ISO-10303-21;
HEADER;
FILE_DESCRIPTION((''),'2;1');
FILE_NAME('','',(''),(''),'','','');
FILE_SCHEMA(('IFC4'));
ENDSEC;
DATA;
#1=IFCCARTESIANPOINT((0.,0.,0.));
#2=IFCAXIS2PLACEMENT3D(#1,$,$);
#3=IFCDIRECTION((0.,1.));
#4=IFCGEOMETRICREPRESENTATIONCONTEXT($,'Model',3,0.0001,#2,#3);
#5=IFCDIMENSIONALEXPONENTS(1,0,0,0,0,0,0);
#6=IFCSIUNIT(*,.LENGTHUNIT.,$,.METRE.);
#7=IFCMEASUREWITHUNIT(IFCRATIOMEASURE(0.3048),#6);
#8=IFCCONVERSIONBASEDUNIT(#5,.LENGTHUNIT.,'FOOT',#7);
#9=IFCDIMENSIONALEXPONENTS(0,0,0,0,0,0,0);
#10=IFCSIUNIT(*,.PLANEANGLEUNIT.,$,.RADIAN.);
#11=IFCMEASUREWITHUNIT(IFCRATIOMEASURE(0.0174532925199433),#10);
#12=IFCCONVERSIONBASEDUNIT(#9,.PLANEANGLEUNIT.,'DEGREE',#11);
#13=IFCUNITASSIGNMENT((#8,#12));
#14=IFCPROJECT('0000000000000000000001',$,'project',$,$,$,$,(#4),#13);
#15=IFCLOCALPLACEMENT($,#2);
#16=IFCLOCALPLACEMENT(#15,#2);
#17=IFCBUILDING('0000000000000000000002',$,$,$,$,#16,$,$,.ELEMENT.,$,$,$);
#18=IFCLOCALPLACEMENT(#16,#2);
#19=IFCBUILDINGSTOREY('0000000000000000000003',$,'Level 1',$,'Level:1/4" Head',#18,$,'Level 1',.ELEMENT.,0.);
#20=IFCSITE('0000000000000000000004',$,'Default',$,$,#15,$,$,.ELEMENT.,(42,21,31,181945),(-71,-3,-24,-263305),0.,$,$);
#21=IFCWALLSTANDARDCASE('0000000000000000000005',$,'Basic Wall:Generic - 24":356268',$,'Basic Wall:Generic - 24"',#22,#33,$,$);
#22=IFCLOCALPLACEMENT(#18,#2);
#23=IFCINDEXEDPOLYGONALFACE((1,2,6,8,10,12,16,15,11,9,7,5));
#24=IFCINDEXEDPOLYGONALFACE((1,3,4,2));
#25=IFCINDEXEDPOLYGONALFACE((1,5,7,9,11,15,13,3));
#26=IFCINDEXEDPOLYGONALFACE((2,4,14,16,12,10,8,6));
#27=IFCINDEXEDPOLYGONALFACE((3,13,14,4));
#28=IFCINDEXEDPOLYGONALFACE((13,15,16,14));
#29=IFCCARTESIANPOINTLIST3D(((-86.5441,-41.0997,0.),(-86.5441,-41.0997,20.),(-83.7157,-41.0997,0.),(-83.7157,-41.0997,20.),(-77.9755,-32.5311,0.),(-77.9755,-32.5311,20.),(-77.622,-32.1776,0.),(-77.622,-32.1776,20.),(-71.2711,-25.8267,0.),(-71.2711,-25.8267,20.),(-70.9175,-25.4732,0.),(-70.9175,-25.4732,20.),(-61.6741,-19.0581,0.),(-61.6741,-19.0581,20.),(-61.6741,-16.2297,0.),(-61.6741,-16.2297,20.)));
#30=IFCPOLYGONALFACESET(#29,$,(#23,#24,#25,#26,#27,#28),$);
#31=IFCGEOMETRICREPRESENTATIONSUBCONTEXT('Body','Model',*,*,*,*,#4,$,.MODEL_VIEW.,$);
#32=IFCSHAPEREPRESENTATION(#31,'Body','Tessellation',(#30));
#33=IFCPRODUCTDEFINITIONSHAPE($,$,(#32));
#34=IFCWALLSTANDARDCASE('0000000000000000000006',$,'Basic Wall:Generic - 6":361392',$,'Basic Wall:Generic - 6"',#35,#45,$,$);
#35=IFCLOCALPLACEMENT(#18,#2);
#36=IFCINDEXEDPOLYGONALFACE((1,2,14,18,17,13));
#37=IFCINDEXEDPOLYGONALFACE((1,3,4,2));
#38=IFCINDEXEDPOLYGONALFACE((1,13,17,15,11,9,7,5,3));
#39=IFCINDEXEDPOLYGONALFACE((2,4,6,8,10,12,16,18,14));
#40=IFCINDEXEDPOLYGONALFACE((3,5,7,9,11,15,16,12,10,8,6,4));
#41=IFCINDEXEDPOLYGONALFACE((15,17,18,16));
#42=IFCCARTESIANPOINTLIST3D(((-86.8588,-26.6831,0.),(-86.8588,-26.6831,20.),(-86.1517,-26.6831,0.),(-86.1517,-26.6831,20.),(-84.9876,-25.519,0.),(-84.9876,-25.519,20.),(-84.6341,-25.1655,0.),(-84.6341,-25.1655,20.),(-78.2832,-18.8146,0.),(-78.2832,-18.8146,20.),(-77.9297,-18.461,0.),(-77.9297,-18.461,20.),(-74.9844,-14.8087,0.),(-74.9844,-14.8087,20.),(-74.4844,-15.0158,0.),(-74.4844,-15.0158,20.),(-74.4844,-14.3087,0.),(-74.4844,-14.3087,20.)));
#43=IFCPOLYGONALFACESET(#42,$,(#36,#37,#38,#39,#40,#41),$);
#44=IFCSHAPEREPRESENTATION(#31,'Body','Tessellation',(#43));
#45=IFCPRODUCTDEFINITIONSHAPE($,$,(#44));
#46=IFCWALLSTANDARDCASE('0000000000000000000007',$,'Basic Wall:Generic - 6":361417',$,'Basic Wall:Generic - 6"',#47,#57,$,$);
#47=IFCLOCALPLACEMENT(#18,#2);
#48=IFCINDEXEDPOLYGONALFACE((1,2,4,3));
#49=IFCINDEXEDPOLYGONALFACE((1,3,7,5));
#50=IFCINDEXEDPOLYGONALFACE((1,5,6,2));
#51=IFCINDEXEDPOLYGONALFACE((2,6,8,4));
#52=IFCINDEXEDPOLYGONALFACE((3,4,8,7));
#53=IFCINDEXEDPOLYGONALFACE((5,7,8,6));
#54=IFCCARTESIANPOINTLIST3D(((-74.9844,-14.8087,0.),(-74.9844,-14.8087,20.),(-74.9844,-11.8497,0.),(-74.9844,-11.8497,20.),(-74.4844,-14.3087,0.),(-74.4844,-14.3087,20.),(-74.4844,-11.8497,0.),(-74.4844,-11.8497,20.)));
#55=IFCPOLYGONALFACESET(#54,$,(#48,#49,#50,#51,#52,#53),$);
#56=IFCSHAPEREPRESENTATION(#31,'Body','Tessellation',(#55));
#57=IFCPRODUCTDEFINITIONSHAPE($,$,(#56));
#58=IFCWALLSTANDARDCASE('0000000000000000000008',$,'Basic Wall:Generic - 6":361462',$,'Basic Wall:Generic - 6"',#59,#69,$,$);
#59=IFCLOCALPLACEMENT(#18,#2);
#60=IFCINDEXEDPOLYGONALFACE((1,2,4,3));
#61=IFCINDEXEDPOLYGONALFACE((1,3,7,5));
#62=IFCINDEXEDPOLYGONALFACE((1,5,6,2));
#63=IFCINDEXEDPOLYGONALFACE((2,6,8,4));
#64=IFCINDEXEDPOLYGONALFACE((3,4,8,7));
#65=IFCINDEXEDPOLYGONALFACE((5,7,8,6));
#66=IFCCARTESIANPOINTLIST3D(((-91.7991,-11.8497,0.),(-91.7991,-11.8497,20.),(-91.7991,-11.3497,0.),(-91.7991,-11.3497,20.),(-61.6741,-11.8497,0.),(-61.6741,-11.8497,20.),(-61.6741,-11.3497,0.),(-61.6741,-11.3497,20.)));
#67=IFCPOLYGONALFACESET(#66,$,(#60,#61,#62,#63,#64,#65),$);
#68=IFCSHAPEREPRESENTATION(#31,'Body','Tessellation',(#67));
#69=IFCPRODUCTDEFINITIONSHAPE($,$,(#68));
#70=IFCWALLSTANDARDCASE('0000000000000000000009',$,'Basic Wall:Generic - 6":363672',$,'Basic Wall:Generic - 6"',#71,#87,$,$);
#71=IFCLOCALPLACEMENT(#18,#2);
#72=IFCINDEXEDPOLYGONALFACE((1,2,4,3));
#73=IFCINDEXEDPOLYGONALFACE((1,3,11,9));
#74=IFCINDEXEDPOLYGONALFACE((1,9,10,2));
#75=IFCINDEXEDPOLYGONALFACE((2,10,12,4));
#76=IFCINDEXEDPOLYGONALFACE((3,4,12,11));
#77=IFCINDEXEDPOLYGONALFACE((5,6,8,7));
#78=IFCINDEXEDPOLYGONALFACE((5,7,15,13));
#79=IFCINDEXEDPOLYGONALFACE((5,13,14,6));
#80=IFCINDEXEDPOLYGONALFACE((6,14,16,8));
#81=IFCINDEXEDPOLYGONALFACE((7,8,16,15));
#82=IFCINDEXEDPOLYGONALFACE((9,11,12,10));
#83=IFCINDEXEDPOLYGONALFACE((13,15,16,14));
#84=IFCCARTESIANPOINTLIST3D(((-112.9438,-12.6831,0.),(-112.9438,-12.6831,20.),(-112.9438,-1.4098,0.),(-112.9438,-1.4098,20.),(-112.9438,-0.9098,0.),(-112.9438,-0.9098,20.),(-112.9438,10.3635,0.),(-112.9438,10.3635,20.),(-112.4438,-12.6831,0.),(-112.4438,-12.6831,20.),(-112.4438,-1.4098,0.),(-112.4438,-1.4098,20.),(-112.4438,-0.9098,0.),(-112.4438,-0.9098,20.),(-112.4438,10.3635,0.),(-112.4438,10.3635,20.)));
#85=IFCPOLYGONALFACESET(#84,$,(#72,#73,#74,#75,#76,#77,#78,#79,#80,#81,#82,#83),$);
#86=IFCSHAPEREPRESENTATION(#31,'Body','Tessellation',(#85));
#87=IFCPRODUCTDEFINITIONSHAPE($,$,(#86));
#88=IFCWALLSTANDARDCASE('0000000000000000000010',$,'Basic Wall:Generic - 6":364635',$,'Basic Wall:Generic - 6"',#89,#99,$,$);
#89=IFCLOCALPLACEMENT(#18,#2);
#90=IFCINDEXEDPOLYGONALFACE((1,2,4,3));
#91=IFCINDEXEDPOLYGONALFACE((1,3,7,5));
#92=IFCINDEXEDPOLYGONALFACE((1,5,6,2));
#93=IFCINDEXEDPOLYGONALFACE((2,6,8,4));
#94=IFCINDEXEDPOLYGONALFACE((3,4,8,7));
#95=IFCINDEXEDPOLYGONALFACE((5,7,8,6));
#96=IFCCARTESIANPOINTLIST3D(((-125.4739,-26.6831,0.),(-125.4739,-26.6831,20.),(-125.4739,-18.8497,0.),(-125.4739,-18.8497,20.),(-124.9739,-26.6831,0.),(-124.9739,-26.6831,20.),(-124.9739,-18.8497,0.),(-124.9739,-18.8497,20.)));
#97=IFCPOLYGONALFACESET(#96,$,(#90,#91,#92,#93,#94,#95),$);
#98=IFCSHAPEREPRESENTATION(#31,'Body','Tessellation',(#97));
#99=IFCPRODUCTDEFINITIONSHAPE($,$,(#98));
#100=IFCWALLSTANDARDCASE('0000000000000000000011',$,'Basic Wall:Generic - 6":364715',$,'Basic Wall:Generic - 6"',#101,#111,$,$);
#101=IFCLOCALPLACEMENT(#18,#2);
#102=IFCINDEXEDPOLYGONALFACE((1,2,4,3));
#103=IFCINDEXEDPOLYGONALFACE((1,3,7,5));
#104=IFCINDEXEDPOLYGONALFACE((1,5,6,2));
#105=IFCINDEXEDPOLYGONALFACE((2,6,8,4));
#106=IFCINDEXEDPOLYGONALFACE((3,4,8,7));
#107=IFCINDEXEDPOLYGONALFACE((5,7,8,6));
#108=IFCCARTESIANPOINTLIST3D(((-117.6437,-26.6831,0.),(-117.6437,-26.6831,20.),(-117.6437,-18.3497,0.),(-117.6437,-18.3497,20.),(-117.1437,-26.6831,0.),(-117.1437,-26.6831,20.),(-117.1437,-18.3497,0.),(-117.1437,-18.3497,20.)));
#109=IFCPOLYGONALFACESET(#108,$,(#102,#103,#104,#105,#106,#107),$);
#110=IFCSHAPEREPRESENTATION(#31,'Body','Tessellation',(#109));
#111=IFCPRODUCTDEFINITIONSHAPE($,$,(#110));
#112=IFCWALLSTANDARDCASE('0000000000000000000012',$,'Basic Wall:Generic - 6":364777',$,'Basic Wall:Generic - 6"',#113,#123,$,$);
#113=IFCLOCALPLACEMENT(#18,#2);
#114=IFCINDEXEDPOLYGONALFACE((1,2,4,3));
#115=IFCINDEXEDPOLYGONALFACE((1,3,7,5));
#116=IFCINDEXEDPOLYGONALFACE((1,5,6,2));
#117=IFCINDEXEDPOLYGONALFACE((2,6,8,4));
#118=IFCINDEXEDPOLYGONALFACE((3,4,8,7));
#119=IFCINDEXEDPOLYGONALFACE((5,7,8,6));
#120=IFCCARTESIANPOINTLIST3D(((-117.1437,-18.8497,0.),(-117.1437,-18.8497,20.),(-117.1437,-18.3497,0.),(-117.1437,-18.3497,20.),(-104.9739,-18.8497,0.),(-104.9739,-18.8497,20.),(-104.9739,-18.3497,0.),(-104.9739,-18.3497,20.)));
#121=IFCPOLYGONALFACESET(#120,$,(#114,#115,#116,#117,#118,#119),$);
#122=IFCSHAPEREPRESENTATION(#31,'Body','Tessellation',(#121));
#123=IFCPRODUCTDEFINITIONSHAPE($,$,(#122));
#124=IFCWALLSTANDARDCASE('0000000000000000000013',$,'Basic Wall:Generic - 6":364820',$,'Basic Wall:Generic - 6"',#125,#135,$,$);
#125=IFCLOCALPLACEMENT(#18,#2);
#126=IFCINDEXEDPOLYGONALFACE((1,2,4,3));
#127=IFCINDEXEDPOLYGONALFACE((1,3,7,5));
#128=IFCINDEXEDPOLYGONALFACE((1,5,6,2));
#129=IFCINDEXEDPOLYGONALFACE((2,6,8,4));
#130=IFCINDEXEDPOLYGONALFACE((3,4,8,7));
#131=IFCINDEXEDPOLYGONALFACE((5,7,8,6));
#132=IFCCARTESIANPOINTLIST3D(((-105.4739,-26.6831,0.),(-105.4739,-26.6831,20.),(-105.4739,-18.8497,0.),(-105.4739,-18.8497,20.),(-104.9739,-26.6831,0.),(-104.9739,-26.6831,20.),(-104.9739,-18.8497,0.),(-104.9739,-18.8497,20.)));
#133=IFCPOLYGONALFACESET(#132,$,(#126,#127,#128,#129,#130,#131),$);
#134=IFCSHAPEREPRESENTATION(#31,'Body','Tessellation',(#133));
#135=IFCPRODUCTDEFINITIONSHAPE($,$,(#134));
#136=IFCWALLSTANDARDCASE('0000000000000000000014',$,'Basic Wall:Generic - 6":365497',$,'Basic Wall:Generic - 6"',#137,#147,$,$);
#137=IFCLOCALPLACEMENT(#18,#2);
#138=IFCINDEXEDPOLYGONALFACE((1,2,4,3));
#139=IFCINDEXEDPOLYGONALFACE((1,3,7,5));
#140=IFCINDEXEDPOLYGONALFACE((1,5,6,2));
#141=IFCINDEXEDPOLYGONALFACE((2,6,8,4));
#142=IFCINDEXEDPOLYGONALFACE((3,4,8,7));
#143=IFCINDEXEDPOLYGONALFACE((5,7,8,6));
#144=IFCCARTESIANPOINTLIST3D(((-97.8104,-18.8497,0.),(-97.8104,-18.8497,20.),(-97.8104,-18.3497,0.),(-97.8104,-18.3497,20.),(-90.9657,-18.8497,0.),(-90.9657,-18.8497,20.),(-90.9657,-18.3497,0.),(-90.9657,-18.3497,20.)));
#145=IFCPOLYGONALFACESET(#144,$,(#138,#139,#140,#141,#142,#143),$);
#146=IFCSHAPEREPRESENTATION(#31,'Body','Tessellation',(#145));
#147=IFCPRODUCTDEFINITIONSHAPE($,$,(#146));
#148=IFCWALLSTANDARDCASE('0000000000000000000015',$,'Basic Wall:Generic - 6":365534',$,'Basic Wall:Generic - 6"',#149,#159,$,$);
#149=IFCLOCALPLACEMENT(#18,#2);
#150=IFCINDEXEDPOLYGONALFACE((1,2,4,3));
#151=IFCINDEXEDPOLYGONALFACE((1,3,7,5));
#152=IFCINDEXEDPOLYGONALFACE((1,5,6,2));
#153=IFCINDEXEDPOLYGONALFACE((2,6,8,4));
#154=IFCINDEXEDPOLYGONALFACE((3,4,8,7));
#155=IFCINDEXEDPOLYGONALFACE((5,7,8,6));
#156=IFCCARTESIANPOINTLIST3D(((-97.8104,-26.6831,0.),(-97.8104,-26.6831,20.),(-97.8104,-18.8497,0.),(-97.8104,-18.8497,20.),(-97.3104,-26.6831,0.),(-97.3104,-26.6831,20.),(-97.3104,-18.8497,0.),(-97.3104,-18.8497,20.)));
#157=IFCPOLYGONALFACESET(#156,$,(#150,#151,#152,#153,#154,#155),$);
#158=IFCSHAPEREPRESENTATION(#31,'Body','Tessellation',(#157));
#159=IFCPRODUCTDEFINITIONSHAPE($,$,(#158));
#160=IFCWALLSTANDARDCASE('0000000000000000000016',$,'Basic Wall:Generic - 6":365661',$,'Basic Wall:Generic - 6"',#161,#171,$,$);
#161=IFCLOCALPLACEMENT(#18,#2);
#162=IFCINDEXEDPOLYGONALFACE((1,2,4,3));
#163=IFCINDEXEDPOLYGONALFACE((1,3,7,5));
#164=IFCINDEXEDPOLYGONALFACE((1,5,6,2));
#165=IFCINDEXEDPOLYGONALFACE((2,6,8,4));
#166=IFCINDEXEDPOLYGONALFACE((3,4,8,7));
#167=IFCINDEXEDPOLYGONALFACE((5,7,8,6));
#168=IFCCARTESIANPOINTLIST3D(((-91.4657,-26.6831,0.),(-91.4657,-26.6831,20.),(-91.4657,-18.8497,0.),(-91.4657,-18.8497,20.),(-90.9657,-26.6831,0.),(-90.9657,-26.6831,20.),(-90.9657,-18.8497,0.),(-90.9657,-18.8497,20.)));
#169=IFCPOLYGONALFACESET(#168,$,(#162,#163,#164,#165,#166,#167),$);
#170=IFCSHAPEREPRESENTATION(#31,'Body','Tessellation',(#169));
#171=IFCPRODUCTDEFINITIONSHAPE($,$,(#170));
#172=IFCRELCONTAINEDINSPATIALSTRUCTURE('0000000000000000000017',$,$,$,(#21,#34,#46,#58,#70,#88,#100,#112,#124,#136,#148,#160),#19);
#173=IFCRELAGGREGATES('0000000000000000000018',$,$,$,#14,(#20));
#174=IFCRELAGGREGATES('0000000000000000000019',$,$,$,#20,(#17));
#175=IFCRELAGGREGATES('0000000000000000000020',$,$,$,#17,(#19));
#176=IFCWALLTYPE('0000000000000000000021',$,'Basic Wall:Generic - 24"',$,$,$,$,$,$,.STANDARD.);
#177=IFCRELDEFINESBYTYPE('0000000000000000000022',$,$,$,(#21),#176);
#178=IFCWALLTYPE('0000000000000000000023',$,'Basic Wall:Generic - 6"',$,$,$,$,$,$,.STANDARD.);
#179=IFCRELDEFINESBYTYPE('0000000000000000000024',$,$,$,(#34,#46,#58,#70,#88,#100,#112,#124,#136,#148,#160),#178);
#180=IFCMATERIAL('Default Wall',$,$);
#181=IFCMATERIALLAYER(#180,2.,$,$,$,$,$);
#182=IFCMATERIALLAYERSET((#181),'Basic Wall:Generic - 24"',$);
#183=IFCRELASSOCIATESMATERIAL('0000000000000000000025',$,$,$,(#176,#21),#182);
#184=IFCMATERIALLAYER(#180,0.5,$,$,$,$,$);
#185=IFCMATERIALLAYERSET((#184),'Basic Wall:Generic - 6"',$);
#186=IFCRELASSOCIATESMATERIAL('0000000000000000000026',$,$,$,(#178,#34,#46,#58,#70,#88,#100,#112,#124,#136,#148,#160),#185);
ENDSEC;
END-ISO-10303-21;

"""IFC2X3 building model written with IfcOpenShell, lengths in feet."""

from ifc_helpers import new_model, entity, si_unit, converted_unit, direction, frame, frame_2d, origin, origin_2d_with_axis, place, context, subcontext, project, spatial, polyline, rectangle, outline, extrude, material, layer, layer_set, layer_usage, type_object, element, save


model = new_model("IFC2X3")

# Units and contexts
model_context = context("Model", 3, precision=0.0001, world=origin(), true_north=direction((0.0, 1.0)))
body_context = subcontext(model_context, "Body", "Model", "MODEL_VIEW")
ifc_project = project(units=[converted_unit("LENGTHUNIT", "FOOT", entity("IfcRatioMeasure", 0.3048), si_unit("LENGTHUNIT", "METRE"), dimensions=[1, 0, 0, 0, 0, 0, 0]), converted_unit("PLANEANGLEUNIT", "DEGREE", entity("IfcRatioMeasure", 0.0174532925199433), si_unit("PLANEANGLEUNIT", "RADIAN"), dimensions=[0, 0, 0, 0, 0, 0, 0])], contexts=[model_context])

# Site, building, storey
site_placement = place(None, origin())
site = spatial("IfcSite", under=ifc_project, at=site_placement, Name="Default", CompositionType="ELEMENT", RefLatitude=(42, 21, 31, 181945), RefLongitude=(-71, -3, -24, -263305), RefElevation=0.0)
building_placement = place(site_placement, origin())
building = spatial("IfcBuilding", under=site, at=building_placement, CompositionType="ELEMENT")
storey_placement = place(building_placement, origin())
storey = spatial("IfcBuildingStorey", under=building, at=storey_placement, Name="Level 1", ObjectType="Level:1/4\" Head", LongName="Level 1", CompositionType="ELEMENT", Elevation=0.0)

# Walls
ifc_material = material(Name="Default Wall")
ifc_layer_1 = layer(ifc_material, 2.0)
ifc_layer_set_1 = layer_set([ifc_layer_1], Name="Basic Wall:Generic - 24\"")
ifc_layer_usage_1 = layer_usage(ifc_layer_set_1, "AXIS2", "NEGATIVE", 1.0)
wall_type_1 = type_object("IfcWallType", Name="Basic Wall:Generic - 24\"", PredefinedType="STANDARD", material=ifc_layer_set_1)
wall_1_placement = place(storey_placement, frame((-85.837, -41.8068, 0.0), z_axis=(0.0, 0.0, 1.0), x_axis=(0.707107, 0.707107, 0.0)))
element("IfcWallStandardCase", 1, at=wall_1_placement, inside=storey, type_object=wall_type_1, material=ifc_layer_usage_1, Name="Basic Wall:Generic - 24\":356268", ObjectType="Basic Wall:Generic - 24\"", context=body_context, shape_type="SweptSolid", body=[
    extrude(outline(polyline([(33.1716, -1.0), (35.1716, 1.0), (22.0993, 1.0), (21.5993, 1.0), (12.6178, 1.0), (12.1178, 1.0), (0.0, 1.0), (2.0, -1.0), (33.1716, -1.0)])), origin(), (0.0, 0.0, 1.0), 20.0),
])
ifc_layer_2 = layer(ifc_material, 0.5)
ifc_layer_set_2 = layer_set([ifc_layer_2], Name="Basic Wall:Generic - 6\"")
ifc_layer_usage_2 = layer_usage(ifc_layer_set_2, "AXIS2", "NEGATIVE", 0.25)
wall_type_2 = type_object("IfcWallType", Name="Basic Wall:Generic - 6\"", PredefinedType="STANDARD", material=ifc_layer_set_2)
wall_2_placement = place(storey_placement, frame((-86.682, -26.8599, 0.0), z_axis=(0.0, 0.0, 1.0), x_axis=(0.707107, 0.707107, 0.0)))
element("IfcWallStandardCase", 2, at=wall_2_placement, inside=storey, type_object=wall_type_2, material=ifc_layer_usage_2, Name="Basic Wall:Generic - 6\":361392", ObjectType="Basic Wall:Generic - 6\"", context=body_context, shape_type="SweptSolid", body=[
    extrude(outline(polyline([(17.0, -0.25), (17.5, 0.25), (16.7929, 0.25), (0.0, 0.25), (0.5, -0.25), (2.1462, -0.25), (2.6462, -0.25), (11.6277, -0.25), (12.1277, -0.25), (17.0, -0.25)])), origin(), (0.0, 0.0, 1.0), 20.0),
])
ifc_layer_usage_3 = layer_usage(ifc_layer_set_2, "AXIS2", "NEGATIVE", 0.25)
wall_3_placement = place(storey_placement, frame((-74.7344, -14.8087, 0.0), z_axis=(0.0, 0.0, 1.0), x_axis=(0.0, 1.0, 0.0)))
element("IfcWallStandardCase", 3, at=wall_3_placement, inside=storey, type_object=wall_type_2, material=ifc_layer_usage_3, Name="Basic Wall:Generic - 6\":361417", ObjectType="Basic Wall:Generic - 6\"", context=body_context, shape_type="SweptSolid", body=[
    extrude(outline(polyline([(2.959, -0.25), (2.959, 0.25), (0.0, 0.25), (0.5, -0.25), (2.959, -0.25)])), origin(), (0.0, 0.0, 1.0), 20.0),
])
ifc_layer_usage_4 = layer_usage(ifc_layer_set_2, "AXIS2", "NEGATIVE", 0.25)
wall_4_placement = place(storey_placement, frame((-91.7991, -11.5997, 0.0)))
element("IfcWallStandardCase", 4, at=wall_4_placement, inside=storey, type_object=wall_type_2, material=ifc_layer_usage_4, Name="Basic Wall:Generic - 6\":361462", ObjectType="Basic Wall:Generic - 6\"", context=body_context, shape_type="SweptSolid", body=[
    extrude(rectangle(XDim=30.125, YDim=0.5, at=frame_2d((15.0625, 0.0), x_axis=(-1.0, 0.0))), origin(), (0.0, 0.0, 1.0), 20.0),
])

# Wall, opening
ifc_layer_usage_5 = layer_usage(ifc_layer_set_2, "AXIS2", "NEGATIVE", 0.25)
wall_5_placement = place(storey_placement, frame((-112.6938, -12.6831, 0.0), z_axis=(0.0, 0.0, 1.0), x_axis=(0.0, 1.0, 0.0)))
wall_5 = element("IfcWallStandardCase", 5, at=wall_5_placement, inside=storey, type_object=wall_type_2, material=ifc_layer_usage_5, Name="Basic Wall:Generic - 6\":363672", ObjectType="Basic Wall:Generic - 6\"", context=body_context, shape_type="SweptSolid", body=[
    extrude(rectangle(XDim=23.0466, YDim=0.5, at=frame_2d((11.5233, 0.0), x_axis=(-1.0, 0.0))), origin(), (0.0, 0.0, 1.0), 20.0),
])
opening_placement = place(storey_placement, frame((-112.6938, -12.6831, 0.0), z_axis=(0.0, 0.0, 1.0), x_axis=(0.0, 1.0, 0.0)))
element("IfcOpeningElement", 6, at=opening_placement, cuts=wall_5, ObjectType="Opening", context=body_context, shape_type="SweptSolid", body=[
    extrude(rectangle(XDim=20.0, YDim=0.5, at=origin_2d_with_axis()), frame((11.2733, 0.0, 10.0), z_axis=(1.0, 0.0, 0.0), x_axis=(0.0, 0.0, -1.0)), (0.0, 0.0, 1.0), 0.5),
])

# Walls
ifc_layer_usage_6 = layer_usage(ifc_layer_set_2, "AXIS2", "NEGATIVE", 0.25)
wall_6_placement = place(storey_placement, frame((-125.2239, -18.8497, 0.0), z_axis=(0.0, 0.0, 1.0), x_axis=(0.0, -1.0, 0.0)))
element("IfcWallStandardCase", 7, at=wall_6_placement, inside=storey, type_object=wall_type_2, material=ifc_layer_usage_6, Name="Basic Wall:Generic - 6\":364635", ObjectType="Basic Wall:Generic - 6\"", context=body_context, shape_type="SweptSolid", body=[
    extrude(rectangle(XDim=7.8333, YDim=0.5, at=frame_2d((3.9167, 0.0), x_axis=(-1.0, 0.0))), origin(), (0.0, 0.0, 1.0), 20.0),
])
ifc_layer_usage_7 = layer_usage(ifc_layer_set_2, "AXIS2", "NEGATIVE", 0.25)
wall_7_placement = place(storey_placement, frame((-117.3937, -26.6831, 0.0), z_axis=(0.0, 0.0, 1.0), x_axis=(0.0, 1.0, 0.0)))
element("IfcWallStandardCase", 8, at=wall_7_placement, inside=storey, type_object=wall_type_2, material=ifc_layer_usage_7, Name="Basic Wall:Generic - 6\":364715", ObjectType="Basic Wall:Generic - 6\"", context=body_context, shape_type="SweptSolid", body=[
    extrude(rectangle(XDim=8.3333, YDim=0.5, at=frame_2d((4.1667, 0.0), x_axis=(-1.0, 0.0))), origin(), (0.0, 0.0, 1.0), 20.0),
])
ifc_layer_usage_8 = layer_usage(ifc_layer_set_2, "AXIS2", "NEGATIVE", 0.25)
wall_8_placement = place(storey_placement, frame((-117.1437, -18.5997, 0.0)))
element("IfcWallStandardCase", 9, at=wall_8_placement, inside=storey, type_object=wall_type_2, material=ifc_layer_usage_8, Name="Basic Wall:Generic - 6\":364777", ObjectType="Basic Wall:Generic - 6\"", context=body_context, shape_type="SweptSolid", body=[
    extrude(rectangle(XDim=12.1698, YDim=0.5, at=frame_2d((6.0849, 0.0), x_axis=(-1.0, 0.0))), origin(), (0.0, 0.0, 1.0), 20.0),
])
ifc_layer_usage_9 = layer_usage(ifc_layer_set_2, "AXIS2", "NEGATIVE", 0.25)
wall_9_placement = place(storey_placement, frame((-105.2239, -18.8497, 0.0), z_axis=(0.0, 0.0, 1.0), x_axis=(0.0, -1.0, 0.0)))
element("IfcWallStandardCase", 10, at=wall_9_placement, inside=storey, type_object=wall_type_2, material=ifc_layer_usage_9, Name="Basic Wall:Generic - 6\":364820", ObjectType="Basic Wall:Generic - 6\"", context=body_context, shape_type="SweptSolid", body=[
    extrude(rectangle(XDim=7.8333, YDim=0.5, at=frame_2d((3.9167, 0.0), x_axis=(-1.0, 0.0))), origin(), (0.0, 0.0, 1.0), 20.0),
])
ifc_layer_usage_10 = layer_usage(ifc_layer_set_2, "AXIS2", "NEGATIVE", 0.25)
wall_10_placement = place(storey_placement, frame((-90.9657, -18.5997, 0.0), z_axis=(0.0, 0.0, 1.0), x_axis=(-1.0, 0.0, 0.0)))
element("IfcWallStandardCase", 11, at=wall_10_placement, inside=storey, type_object=wall_type_2, material=ifc_layer_usage_10, Name="Basic Wall:Generic - 6\":365497", ObjectType="Basic Wall:Generic - 6\"", context=body_context, shape_type="SweptSolid", body=[
    extrude(rectangle(XDim=6.8446, YDim=0.5, at=frame_2d((3.4223, 0.0), x_axis=(-1.0, 0.0))), origin(), (0.0, 0.0, 1.0), 20.0),
])
ifc_layer_usage_11 = layer_usage(ifc_layer_set_2, "AXIS2", "NEGATIVE", 0.25)
wall_11_placement = place(storey_placement, frame((-97.5604, -18.8497, 0.0), z_axis=(0.0, 0.0, 1.0), x_axis=(0.0, -1.0, 0.0)))
element("IfcWallStandardCase", 12, at=wall_11_placement, inside=storey, type_object=wall_type_2, material=ifc_layer_usage_11, Name="Basic Wall:Generic - 6\":365534", ObjectType="Basic Wall:Generic - 6\"", context=body_context, shape_type="SweptSolid", body=[
    extrude(rectangle(XDim=7.8333, YDim=0.5, at=frame_2d((3.9167, 0.0), x_axis=(-1.0, 0.0))), origin(), (0.0, 0.0, 1.0), 20.0),
])
ifc_layer_usage_12 = layer_usage(ifc_layer_set_2, "AXIS2", "NEGATIVE", 0.25)
wall_12_placement = place(storey_placement, frame((-91.2157, -18.8497, 0.0), z_axis=(0.0, 0.0, 1.0), x_axis=(0.0, -1.0, 0.0)))
element("IfcWallStandardCase", 13, at=wall_12_placement, inside=storey, type_object=wall_type_2, material=ifc_layer_usage_12, Name="Basic Wall:Generic - 6\":365661", ObjectType="Basic Wall:Generic - 6\"", context=body_context, shape_type="SweptSolid", body=[
    extrude(rectangle(XDim=7.8333, YDim=0.5, at=frame_2d((3.9167, 0.0), x_axis=(-1.0, 0.0))), origin(), (0.0, 0.0, 1.0), 20.0),
])

save(model, "model.ifc")
